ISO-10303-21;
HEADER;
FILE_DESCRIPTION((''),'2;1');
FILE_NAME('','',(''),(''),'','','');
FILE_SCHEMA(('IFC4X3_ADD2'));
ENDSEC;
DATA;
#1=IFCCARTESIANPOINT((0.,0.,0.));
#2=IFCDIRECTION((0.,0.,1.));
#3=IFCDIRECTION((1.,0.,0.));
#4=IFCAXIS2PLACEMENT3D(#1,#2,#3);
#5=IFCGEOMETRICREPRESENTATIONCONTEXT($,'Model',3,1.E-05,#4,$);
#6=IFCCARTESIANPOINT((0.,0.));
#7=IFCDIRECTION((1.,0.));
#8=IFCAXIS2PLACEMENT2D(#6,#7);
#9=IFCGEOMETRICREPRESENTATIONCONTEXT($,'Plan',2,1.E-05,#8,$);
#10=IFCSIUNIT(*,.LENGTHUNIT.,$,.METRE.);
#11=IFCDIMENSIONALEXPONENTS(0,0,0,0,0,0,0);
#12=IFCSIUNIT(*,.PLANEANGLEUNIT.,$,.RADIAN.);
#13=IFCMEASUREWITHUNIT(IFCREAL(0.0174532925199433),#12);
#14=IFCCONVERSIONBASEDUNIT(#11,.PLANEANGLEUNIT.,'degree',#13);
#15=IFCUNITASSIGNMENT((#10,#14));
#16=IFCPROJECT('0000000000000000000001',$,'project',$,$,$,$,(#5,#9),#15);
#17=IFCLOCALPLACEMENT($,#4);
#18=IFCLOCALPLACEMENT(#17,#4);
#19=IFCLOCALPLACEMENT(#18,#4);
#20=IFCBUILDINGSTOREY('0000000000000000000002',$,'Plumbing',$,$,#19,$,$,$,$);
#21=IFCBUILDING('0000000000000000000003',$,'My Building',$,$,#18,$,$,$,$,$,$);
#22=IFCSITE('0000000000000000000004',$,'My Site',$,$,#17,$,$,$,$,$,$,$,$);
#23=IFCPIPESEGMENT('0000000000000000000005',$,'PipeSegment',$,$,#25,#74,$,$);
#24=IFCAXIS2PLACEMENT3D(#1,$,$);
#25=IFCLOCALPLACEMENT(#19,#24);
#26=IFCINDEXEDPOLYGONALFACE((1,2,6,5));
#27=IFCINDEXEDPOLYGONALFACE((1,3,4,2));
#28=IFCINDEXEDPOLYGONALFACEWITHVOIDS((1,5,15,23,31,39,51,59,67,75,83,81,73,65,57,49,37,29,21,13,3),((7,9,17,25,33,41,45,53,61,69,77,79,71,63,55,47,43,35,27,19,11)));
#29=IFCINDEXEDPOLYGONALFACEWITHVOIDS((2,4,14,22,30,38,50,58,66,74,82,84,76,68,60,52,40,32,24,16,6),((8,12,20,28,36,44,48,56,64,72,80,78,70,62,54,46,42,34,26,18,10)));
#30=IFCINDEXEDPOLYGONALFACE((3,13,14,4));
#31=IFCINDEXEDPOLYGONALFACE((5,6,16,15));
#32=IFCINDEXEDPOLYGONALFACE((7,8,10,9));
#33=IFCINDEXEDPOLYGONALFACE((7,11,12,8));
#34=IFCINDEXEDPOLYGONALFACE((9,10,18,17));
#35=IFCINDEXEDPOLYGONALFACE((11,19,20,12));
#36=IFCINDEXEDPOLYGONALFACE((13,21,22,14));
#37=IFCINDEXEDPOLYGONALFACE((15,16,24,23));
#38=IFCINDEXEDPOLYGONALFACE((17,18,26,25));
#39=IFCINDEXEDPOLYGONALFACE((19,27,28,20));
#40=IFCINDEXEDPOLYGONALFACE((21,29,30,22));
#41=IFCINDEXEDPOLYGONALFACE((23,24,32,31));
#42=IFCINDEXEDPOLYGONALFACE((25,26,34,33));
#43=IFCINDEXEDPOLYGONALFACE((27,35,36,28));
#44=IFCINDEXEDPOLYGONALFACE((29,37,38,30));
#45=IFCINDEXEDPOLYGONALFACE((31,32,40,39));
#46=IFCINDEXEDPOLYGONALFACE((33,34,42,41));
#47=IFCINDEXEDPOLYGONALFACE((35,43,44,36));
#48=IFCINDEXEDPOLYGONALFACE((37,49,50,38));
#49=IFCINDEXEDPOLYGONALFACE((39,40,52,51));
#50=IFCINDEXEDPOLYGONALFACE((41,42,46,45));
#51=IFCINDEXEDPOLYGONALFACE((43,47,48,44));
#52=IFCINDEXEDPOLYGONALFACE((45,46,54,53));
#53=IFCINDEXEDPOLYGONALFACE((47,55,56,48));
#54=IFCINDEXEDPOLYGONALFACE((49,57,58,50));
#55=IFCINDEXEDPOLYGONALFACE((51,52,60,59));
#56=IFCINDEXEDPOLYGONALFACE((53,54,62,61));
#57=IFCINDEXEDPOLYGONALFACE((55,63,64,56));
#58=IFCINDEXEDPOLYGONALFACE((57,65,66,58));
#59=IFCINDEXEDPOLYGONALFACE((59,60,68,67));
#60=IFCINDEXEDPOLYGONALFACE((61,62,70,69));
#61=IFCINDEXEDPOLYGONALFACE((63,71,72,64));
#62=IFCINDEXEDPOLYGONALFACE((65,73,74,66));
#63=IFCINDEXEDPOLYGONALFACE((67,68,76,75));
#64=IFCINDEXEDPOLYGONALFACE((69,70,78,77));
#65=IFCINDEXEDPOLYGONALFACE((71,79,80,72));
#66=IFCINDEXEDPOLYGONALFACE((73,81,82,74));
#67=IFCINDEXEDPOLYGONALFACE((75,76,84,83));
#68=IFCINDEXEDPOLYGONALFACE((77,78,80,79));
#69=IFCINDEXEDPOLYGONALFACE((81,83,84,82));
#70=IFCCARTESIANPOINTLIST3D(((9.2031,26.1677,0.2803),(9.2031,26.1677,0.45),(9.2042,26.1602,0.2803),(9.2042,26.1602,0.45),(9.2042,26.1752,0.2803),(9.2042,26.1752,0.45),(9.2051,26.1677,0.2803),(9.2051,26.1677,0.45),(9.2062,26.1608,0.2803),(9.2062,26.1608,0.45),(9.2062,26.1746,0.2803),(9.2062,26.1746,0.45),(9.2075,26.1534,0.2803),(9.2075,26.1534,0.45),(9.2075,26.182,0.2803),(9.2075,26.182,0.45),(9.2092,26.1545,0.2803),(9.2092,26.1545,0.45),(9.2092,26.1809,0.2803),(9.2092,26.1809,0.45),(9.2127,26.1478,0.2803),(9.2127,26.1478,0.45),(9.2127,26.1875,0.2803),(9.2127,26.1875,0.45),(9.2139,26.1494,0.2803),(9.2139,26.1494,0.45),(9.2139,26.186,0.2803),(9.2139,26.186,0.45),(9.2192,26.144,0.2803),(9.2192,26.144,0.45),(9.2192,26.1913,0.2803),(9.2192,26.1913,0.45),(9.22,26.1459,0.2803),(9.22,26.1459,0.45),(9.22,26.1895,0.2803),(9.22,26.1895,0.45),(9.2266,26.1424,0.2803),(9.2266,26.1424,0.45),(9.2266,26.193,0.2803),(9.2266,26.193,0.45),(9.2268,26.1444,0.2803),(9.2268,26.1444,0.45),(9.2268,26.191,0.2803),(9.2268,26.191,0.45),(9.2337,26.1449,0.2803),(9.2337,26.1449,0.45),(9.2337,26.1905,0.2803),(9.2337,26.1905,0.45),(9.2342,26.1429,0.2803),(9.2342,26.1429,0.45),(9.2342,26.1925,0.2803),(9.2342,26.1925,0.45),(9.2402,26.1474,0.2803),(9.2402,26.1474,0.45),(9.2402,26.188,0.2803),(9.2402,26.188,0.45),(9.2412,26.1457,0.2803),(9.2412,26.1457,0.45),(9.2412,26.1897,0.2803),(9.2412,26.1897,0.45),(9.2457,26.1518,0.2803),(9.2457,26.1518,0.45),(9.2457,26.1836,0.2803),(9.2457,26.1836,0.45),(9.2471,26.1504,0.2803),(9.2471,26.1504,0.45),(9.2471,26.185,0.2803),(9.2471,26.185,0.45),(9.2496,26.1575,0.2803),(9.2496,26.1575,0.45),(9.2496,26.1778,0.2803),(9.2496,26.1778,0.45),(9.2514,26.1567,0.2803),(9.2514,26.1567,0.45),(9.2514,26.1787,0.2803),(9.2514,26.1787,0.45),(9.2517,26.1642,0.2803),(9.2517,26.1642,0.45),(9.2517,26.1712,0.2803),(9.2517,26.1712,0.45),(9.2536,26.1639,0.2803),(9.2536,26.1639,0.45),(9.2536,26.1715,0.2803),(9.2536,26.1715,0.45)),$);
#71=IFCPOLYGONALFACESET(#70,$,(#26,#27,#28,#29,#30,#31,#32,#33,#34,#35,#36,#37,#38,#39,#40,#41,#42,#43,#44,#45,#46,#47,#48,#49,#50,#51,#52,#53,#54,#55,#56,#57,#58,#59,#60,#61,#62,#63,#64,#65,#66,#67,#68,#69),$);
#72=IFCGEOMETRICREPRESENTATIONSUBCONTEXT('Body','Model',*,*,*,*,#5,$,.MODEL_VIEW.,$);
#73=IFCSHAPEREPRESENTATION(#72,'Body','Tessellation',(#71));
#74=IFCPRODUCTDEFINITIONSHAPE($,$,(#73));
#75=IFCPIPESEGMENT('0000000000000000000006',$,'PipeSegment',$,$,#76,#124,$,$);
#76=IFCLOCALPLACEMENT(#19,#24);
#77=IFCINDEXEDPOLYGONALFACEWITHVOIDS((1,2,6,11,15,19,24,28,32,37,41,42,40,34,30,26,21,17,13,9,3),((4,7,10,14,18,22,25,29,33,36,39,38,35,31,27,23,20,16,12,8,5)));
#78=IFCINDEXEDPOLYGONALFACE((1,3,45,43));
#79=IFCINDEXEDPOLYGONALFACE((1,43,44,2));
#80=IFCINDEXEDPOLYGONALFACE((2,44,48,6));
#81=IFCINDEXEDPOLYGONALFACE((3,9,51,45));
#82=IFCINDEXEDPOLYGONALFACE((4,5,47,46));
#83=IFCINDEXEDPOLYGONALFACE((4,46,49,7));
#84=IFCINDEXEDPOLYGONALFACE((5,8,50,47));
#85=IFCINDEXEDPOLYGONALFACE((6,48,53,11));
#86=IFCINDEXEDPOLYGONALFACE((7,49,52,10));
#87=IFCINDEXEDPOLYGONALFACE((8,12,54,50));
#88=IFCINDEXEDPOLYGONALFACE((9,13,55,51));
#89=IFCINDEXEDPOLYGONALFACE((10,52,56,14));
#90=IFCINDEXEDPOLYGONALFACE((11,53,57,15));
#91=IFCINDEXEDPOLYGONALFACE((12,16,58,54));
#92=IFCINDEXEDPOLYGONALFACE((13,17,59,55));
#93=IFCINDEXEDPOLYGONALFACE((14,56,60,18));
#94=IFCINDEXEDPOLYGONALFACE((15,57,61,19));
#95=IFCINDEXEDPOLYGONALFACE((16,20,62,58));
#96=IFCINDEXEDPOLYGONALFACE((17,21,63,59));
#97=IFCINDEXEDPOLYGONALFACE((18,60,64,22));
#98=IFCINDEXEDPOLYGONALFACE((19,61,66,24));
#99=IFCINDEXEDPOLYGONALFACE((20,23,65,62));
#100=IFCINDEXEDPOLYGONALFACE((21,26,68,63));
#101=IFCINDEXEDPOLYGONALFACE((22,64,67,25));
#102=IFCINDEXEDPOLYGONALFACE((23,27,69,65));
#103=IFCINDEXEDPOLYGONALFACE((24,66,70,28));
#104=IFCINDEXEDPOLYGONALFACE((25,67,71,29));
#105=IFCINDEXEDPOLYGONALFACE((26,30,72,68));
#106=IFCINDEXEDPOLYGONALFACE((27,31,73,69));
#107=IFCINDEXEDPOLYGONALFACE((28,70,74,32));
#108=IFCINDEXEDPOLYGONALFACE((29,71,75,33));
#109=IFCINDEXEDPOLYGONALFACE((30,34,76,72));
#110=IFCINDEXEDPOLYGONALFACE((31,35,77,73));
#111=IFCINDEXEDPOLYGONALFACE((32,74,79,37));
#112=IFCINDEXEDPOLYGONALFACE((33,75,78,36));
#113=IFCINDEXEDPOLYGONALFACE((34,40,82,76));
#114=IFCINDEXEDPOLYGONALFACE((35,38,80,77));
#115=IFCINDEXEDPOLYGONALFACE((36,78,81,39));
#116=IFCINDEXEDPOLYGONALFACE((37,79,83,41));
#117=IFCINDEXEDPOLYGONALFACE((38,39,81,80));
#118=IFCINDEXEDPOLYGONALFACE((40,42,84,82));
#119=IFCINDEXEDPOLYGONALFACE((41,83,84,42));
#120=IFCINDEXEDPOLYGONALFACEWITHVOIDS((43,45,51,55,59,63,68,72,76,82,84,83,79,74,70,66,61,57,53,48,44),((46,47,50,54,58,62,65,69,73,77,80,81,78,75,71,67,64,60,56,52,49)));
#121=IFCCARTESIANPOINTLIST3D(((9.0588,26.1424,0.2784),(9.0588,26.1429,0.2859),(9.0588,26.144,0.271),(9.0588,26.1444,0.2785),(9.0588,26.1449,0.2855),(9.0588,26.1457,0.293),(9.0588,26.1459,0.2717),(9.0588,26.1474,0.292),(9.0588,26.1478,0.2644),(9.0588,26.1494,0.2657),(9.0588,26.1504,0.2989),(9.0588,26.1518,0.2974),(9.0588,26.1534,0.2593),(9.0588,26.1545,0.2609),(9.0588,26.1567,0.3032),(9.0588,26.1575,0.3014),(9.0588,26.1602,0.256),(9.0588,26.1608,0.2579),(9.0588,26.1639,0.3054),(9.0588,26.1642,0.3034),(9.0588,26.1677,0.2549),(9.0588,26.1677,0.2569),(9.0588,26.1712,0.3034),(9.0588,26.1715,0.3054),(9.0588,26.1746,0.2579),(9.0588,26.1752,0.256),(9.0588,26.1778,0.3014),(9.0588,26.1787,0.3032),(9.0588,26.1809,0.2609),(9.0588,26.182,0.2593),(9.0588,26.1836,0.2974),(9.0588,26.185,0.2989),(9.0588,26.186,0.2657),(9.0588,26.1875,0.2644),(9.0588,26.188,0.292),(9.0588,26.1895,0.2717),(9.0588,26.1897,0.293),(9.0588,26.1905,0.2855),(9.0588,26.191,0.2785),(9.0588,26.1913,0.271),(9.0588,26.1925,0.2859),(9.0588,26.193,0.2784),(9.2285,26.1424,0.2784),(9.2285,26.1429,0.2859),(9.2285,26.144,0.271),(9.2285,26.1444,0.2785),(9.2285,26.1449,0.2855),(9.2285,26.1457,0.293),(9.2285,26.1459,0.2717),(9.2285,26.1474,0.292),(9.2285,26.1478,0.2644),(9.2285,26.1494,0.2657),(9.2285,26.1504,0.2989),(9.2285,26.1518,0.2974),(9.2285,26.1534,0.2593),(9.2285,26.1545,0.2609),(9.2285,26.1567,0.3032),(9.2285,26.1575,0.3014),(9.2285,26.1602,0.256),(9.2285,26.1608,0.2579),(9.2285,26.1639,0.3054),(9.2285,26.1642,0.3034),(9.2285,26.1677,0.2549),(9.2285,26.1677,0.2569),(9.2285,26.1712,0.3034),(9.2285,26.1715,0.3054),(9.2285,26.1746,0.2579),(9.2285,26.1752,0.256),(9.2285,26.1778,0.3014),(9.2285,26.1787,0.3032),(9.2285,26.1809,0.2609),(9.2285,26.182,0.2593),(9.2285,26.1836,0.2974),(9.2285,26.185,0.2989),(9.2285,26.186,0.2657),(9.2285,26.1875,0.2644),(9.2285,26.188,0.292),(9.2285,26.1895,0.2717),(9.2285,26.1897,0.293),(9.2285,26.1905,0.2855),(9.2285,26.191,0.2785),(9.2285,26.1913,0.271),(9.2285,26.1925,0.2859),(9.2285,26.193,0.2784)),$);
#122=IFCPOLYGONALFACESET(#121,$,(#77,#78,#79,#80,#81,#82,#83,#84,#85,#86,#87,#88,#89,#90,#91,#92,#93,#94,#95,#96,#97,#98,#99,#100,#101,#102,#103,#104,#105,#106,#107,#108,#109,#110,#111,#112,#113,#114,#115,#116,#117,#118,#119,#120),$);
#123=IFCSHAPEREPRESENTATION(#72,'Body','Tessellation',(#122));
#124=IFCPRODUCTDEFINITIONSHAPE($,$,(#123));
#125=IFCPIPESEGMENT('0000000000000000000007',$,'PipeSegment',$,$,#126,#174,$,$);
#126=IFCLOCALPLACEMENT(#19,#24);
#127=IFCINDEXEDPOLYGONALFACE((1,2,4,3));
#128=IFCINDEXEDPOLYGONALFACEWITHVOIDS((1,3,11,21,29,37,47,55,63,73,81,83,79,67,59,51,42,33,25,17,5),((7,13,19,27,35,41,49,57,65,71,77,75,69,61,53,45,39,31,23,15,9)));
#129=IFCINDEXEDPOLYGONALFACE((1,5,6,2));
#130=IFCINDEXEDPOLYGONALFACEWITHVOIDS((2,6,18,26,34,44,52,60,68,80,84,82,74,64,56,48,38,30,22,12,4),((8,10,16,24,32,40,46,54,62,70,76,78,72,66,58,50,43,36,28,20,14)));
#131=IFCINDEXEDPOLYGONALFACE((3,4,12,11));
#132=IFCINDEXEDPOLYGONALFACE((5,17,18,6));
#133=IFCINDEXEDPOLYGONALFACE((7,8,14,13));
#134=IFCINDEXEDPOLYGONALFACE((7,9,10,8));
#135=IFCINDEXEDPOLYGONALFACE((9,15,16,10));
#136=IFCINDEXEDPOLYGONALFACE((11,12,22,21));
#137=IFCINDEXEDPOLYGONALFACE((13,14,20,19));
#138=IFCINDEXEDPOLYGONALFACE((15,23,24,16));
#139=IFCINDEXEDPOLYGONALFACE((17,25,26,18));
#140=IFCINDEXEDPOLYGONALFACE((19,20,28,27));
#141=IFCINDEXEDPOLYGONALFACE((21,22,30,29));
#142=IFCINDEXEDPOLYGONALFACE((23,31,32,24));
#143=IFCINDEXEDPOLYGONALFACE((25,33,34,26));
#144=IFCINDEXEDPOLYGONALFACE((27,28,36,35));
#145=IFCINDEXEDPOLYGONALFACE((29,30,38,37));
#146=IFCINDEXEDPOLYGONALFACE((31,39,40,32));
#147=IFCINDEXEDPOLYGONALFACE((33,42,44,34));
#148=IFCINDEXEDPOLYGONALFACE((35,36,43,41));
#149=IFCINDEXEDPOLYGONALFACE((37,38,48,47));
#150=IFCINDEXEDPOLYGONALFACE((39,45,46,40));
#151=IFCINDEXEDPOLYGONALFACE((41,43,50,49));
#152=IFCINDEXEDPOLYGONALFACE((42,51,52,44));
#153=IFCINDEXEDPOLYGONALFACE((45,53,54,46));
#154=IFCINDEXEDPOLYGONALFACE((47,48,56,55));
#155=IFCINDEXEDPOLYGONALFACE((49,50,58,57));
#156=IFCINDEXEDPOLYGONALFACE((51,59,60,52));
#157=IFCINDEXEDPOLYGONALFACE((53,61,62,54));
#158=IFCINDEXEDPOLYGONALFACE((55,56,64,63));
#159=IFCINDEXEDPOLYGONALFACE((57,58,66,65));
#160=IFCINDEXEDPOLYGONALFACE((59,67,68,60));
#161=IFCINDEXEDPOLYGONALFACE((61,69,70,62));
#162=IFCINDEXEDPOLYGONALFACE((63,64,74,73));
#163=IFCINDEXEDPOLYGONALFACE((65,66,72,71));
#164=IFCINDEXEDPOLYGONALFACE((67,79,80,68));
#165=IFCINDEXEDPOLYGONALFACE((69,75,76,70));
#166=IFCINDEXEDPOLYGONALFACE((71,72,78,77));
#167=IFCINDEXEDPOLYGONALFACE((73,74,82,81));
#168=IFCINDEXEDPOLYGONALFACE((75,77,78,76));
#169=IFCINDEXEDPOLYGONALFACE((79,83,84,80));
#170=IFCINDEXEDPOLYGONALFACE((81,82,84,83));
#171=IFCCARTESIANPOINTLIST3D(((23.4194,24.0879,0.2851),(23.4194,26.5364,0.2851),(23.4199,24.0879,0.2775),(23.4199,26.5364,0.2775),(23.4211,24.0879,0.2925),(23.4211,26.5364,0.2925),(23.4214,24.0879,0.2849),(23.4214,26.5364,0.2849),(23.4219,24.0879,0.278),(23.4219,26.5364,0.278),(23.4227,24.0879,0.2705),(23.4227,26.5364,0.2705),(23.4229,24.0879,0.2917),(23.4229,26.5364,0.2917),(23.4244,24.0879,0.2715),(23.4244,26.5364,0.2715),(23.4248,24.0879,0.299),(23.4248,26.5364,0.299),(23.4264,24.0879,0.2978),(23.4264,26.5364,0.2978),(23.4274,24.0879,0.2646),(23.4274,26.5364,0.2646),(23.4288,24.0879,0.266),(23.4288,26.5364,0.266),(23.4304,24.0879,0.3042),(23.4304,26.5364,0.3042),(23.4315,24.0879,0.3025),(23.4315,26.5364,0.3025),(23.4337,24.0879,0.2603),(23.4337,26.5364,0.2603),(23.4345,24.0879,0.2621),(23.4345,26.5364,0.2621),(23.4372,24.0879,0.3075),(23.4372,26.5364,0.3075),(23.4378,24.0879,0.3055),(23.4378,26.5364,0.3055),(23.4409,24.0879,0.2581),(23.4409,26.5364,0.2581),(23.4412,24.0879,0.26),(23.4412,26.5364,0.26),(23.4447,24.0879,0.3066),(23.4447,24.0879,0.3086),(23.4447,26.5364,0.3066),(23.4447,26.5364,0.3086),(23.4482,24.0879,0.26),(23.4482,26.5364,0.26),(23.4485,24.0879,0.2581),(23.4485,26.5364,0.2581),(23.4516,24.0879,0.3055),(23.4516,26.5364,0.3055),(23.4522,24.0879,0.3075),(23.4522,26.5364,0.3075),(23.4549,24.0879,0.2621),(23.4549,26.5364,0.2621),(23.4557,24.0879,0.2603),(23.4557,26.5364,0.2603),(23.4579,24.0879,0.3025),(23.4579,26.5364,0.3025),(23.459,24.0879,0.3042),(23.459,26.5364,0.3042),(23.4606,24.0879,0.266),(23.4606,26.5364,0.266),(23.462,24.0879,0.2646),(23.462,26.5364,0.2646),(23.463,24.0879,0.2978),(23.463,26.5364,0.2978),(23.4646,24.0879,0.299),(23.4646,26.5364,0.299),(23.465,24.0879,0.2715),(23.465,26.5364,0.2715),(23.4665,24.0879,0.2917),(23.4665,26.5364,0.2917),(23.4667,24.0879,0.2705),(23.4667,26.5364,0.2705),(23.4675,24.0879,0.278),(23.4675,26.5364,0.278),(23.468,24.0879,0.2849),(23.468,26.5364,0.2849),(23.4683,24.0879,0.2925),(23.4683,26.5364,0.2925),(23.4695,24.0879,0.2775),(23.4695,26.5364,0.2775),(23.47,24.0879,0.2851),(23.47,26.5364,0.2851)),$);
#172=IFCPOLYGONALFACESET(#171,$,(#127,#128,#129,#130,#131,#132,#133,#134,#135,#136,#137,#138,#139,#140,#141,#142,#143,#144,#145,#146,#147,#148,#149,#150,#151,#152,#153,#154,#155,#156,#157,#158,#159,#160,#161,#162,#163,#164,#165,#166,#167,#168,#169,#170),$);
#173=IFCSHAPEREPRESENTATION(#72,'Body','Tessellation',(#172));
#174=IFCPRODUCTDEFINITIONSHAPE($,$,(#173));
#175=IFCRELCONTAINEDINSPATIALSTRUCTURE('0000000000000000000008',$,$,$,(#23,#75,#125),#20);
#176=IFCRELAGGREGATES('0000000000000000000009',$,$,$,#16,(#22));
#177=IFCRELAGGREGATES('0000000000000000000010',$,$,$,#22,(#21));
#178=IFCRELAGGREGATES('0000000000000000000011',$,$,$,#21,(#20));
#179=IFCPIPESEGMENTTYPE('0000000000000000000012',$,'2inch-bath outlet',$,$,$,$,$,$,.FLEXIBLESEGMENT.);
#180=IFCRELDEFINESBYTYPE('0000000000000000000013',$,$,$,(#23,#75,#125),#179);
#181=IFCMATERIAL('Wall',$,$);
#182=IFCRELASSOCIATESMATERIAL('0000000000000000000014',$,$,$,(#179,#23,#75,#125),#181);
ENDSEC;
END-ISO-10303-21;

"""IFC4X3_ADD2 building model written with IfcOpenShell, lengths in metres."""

from ifc_helpers import new_model, entity, si_unit, converted_unit, frame, origin_with_axes, origin_2d_with_axis, place, context, subcontext, project, spatial, hollow_circle, extrude, material, material_profile, profile_set, profile_usage, type_object, element, save


model = new_model("IFC4X3_ADD2")

# Units and contexts
model_context = context("Model", 3, precision=1e-05, world=origin_with_axes())
plan_context = context("Plan", 2, precision=1e-05, world=origin_2d_with_axis())
body_context = subcontext(model_context, "Body", "Model", "MODEL_VIEW")
ifc_project = project(units=[si_unit("LENGTHUNIT", "METRE"), converted_unit("PLANEANGLEUNIT", "degree", entity("IfcReal", 0.0174532925199433), si_unit("PLANEANGLEUNIT", "RADIAN"), dimensions=[0, 0, 0, 0, 0, 0, 0])], contexts=[model_context, plan_context])

# Site, building, storey
site_placement = place(None, origin_with_axes())
site = spatial("IfcSite", under=ifc_project, at=site_placement, Name="My Site")
building_placement = place(site_placement, origin_with_axes())
building = spatial("IfcBuilding", under=site, at=building_placement, Name="My Building")
storey_placement = place(building_placement, origin_with_axes())
storey = spatial("IfcBuildingStorey", under=building, at=storey_placement, Name="Plumbing")

# Pipe segments
ifc_material_1 = material(Name="Wall")
ifc_material_profile_1 = material_profile(ifc_material_1, hollow_circle(Radius=0.0254, WallThickness=0.002))
ifc_profile_set_1 = profile_set([ifc_material_profile_1], Name="graywater")
ifc_material_profile_2 = material_profile(ifc_material_1, hollow_circle(Radius=0.0254, WallThickness=0.002))
ifc_profile_set_2 = profile_set([ifc_material_profile_2], Name="graywater")
pipe_segment_type_1 = type_object("IfcPipeSegmentType", Name="2inch-bath outlet", PredefinedType="FLEXIBLESEGMENT", material=ifc_profile_set_2)
ifc_profile_usage_1 = profile_usage(ifc_profile_set_1)
pipe_segment_1_placement = place(storey_placement, frame((9.2285, 26.1677, 0.2803), z_axis=(0.0, 0.0, 1.0), x_axis=(-1.0, 0.0, 0.0)))
element("IfcPipeSegment", 1, at=pipe_segment_1_placement, inside=storey, type_object=pipe_segment_type_1, material=ifc_profile_usage_1, Name="PipeSegment", context=body_context, shape_type="SweptSolid", body=[
    extrude(hollow_circle(Radius=0.0254, WallThickness=0.002), origin_with_axes(), (0.0, 0.0, 1.0), 0.1697),
])
ifc_profile_usage_2 = profile_usage(ifc_profile_set_1)
pipe_segment_2_placement = place(storey_placement, frame((9.2285, 26.1677, 0.2803), z_axis=(-1.0, 0.0, 0.0), x_axis=(0.0, 0.0, -1.0)))
element("IfcPipeSegment", 2, at=pipe_segment_2_placement, inside=storey, type_object=pipe_segment_type_1, material=ifc_profile_usage_2, Name="PipeSegment", context=body_context, shape_type="SweptSolid", body=[
    extrude(hollow_circle(Radius=0.0254, WallThickness=0.002), origin_with_axes(), (0.0, 0.0, 1.0), 0.1697),
])
ifc_profile_usage_3 = profile_usage(ifc_profile_set_1)
pipe_segment_3_placement = place(storey_placement, frame((23.4447, 24.0879, 0.2832), z_axis=(0.0, 1.0, 0.0), x_axis=(0.0, 0.0, 1.0)))
element("IfcPipeSegment", 3, at=pipe_segment_3_placement, inside=storey, type_object=pipe_segment_type_1, material=ifc_profile_usage_3, Name="PipeSegment", context=body_context, shape_type="SweptSolid", body=[
    extrude(hollow_circle(Radius=0.0254, WallThickness=0.002), origin_with_axes(), (0.0, 0.0, 1.0), 2.4485),
])

save(model, "model.ifc")
